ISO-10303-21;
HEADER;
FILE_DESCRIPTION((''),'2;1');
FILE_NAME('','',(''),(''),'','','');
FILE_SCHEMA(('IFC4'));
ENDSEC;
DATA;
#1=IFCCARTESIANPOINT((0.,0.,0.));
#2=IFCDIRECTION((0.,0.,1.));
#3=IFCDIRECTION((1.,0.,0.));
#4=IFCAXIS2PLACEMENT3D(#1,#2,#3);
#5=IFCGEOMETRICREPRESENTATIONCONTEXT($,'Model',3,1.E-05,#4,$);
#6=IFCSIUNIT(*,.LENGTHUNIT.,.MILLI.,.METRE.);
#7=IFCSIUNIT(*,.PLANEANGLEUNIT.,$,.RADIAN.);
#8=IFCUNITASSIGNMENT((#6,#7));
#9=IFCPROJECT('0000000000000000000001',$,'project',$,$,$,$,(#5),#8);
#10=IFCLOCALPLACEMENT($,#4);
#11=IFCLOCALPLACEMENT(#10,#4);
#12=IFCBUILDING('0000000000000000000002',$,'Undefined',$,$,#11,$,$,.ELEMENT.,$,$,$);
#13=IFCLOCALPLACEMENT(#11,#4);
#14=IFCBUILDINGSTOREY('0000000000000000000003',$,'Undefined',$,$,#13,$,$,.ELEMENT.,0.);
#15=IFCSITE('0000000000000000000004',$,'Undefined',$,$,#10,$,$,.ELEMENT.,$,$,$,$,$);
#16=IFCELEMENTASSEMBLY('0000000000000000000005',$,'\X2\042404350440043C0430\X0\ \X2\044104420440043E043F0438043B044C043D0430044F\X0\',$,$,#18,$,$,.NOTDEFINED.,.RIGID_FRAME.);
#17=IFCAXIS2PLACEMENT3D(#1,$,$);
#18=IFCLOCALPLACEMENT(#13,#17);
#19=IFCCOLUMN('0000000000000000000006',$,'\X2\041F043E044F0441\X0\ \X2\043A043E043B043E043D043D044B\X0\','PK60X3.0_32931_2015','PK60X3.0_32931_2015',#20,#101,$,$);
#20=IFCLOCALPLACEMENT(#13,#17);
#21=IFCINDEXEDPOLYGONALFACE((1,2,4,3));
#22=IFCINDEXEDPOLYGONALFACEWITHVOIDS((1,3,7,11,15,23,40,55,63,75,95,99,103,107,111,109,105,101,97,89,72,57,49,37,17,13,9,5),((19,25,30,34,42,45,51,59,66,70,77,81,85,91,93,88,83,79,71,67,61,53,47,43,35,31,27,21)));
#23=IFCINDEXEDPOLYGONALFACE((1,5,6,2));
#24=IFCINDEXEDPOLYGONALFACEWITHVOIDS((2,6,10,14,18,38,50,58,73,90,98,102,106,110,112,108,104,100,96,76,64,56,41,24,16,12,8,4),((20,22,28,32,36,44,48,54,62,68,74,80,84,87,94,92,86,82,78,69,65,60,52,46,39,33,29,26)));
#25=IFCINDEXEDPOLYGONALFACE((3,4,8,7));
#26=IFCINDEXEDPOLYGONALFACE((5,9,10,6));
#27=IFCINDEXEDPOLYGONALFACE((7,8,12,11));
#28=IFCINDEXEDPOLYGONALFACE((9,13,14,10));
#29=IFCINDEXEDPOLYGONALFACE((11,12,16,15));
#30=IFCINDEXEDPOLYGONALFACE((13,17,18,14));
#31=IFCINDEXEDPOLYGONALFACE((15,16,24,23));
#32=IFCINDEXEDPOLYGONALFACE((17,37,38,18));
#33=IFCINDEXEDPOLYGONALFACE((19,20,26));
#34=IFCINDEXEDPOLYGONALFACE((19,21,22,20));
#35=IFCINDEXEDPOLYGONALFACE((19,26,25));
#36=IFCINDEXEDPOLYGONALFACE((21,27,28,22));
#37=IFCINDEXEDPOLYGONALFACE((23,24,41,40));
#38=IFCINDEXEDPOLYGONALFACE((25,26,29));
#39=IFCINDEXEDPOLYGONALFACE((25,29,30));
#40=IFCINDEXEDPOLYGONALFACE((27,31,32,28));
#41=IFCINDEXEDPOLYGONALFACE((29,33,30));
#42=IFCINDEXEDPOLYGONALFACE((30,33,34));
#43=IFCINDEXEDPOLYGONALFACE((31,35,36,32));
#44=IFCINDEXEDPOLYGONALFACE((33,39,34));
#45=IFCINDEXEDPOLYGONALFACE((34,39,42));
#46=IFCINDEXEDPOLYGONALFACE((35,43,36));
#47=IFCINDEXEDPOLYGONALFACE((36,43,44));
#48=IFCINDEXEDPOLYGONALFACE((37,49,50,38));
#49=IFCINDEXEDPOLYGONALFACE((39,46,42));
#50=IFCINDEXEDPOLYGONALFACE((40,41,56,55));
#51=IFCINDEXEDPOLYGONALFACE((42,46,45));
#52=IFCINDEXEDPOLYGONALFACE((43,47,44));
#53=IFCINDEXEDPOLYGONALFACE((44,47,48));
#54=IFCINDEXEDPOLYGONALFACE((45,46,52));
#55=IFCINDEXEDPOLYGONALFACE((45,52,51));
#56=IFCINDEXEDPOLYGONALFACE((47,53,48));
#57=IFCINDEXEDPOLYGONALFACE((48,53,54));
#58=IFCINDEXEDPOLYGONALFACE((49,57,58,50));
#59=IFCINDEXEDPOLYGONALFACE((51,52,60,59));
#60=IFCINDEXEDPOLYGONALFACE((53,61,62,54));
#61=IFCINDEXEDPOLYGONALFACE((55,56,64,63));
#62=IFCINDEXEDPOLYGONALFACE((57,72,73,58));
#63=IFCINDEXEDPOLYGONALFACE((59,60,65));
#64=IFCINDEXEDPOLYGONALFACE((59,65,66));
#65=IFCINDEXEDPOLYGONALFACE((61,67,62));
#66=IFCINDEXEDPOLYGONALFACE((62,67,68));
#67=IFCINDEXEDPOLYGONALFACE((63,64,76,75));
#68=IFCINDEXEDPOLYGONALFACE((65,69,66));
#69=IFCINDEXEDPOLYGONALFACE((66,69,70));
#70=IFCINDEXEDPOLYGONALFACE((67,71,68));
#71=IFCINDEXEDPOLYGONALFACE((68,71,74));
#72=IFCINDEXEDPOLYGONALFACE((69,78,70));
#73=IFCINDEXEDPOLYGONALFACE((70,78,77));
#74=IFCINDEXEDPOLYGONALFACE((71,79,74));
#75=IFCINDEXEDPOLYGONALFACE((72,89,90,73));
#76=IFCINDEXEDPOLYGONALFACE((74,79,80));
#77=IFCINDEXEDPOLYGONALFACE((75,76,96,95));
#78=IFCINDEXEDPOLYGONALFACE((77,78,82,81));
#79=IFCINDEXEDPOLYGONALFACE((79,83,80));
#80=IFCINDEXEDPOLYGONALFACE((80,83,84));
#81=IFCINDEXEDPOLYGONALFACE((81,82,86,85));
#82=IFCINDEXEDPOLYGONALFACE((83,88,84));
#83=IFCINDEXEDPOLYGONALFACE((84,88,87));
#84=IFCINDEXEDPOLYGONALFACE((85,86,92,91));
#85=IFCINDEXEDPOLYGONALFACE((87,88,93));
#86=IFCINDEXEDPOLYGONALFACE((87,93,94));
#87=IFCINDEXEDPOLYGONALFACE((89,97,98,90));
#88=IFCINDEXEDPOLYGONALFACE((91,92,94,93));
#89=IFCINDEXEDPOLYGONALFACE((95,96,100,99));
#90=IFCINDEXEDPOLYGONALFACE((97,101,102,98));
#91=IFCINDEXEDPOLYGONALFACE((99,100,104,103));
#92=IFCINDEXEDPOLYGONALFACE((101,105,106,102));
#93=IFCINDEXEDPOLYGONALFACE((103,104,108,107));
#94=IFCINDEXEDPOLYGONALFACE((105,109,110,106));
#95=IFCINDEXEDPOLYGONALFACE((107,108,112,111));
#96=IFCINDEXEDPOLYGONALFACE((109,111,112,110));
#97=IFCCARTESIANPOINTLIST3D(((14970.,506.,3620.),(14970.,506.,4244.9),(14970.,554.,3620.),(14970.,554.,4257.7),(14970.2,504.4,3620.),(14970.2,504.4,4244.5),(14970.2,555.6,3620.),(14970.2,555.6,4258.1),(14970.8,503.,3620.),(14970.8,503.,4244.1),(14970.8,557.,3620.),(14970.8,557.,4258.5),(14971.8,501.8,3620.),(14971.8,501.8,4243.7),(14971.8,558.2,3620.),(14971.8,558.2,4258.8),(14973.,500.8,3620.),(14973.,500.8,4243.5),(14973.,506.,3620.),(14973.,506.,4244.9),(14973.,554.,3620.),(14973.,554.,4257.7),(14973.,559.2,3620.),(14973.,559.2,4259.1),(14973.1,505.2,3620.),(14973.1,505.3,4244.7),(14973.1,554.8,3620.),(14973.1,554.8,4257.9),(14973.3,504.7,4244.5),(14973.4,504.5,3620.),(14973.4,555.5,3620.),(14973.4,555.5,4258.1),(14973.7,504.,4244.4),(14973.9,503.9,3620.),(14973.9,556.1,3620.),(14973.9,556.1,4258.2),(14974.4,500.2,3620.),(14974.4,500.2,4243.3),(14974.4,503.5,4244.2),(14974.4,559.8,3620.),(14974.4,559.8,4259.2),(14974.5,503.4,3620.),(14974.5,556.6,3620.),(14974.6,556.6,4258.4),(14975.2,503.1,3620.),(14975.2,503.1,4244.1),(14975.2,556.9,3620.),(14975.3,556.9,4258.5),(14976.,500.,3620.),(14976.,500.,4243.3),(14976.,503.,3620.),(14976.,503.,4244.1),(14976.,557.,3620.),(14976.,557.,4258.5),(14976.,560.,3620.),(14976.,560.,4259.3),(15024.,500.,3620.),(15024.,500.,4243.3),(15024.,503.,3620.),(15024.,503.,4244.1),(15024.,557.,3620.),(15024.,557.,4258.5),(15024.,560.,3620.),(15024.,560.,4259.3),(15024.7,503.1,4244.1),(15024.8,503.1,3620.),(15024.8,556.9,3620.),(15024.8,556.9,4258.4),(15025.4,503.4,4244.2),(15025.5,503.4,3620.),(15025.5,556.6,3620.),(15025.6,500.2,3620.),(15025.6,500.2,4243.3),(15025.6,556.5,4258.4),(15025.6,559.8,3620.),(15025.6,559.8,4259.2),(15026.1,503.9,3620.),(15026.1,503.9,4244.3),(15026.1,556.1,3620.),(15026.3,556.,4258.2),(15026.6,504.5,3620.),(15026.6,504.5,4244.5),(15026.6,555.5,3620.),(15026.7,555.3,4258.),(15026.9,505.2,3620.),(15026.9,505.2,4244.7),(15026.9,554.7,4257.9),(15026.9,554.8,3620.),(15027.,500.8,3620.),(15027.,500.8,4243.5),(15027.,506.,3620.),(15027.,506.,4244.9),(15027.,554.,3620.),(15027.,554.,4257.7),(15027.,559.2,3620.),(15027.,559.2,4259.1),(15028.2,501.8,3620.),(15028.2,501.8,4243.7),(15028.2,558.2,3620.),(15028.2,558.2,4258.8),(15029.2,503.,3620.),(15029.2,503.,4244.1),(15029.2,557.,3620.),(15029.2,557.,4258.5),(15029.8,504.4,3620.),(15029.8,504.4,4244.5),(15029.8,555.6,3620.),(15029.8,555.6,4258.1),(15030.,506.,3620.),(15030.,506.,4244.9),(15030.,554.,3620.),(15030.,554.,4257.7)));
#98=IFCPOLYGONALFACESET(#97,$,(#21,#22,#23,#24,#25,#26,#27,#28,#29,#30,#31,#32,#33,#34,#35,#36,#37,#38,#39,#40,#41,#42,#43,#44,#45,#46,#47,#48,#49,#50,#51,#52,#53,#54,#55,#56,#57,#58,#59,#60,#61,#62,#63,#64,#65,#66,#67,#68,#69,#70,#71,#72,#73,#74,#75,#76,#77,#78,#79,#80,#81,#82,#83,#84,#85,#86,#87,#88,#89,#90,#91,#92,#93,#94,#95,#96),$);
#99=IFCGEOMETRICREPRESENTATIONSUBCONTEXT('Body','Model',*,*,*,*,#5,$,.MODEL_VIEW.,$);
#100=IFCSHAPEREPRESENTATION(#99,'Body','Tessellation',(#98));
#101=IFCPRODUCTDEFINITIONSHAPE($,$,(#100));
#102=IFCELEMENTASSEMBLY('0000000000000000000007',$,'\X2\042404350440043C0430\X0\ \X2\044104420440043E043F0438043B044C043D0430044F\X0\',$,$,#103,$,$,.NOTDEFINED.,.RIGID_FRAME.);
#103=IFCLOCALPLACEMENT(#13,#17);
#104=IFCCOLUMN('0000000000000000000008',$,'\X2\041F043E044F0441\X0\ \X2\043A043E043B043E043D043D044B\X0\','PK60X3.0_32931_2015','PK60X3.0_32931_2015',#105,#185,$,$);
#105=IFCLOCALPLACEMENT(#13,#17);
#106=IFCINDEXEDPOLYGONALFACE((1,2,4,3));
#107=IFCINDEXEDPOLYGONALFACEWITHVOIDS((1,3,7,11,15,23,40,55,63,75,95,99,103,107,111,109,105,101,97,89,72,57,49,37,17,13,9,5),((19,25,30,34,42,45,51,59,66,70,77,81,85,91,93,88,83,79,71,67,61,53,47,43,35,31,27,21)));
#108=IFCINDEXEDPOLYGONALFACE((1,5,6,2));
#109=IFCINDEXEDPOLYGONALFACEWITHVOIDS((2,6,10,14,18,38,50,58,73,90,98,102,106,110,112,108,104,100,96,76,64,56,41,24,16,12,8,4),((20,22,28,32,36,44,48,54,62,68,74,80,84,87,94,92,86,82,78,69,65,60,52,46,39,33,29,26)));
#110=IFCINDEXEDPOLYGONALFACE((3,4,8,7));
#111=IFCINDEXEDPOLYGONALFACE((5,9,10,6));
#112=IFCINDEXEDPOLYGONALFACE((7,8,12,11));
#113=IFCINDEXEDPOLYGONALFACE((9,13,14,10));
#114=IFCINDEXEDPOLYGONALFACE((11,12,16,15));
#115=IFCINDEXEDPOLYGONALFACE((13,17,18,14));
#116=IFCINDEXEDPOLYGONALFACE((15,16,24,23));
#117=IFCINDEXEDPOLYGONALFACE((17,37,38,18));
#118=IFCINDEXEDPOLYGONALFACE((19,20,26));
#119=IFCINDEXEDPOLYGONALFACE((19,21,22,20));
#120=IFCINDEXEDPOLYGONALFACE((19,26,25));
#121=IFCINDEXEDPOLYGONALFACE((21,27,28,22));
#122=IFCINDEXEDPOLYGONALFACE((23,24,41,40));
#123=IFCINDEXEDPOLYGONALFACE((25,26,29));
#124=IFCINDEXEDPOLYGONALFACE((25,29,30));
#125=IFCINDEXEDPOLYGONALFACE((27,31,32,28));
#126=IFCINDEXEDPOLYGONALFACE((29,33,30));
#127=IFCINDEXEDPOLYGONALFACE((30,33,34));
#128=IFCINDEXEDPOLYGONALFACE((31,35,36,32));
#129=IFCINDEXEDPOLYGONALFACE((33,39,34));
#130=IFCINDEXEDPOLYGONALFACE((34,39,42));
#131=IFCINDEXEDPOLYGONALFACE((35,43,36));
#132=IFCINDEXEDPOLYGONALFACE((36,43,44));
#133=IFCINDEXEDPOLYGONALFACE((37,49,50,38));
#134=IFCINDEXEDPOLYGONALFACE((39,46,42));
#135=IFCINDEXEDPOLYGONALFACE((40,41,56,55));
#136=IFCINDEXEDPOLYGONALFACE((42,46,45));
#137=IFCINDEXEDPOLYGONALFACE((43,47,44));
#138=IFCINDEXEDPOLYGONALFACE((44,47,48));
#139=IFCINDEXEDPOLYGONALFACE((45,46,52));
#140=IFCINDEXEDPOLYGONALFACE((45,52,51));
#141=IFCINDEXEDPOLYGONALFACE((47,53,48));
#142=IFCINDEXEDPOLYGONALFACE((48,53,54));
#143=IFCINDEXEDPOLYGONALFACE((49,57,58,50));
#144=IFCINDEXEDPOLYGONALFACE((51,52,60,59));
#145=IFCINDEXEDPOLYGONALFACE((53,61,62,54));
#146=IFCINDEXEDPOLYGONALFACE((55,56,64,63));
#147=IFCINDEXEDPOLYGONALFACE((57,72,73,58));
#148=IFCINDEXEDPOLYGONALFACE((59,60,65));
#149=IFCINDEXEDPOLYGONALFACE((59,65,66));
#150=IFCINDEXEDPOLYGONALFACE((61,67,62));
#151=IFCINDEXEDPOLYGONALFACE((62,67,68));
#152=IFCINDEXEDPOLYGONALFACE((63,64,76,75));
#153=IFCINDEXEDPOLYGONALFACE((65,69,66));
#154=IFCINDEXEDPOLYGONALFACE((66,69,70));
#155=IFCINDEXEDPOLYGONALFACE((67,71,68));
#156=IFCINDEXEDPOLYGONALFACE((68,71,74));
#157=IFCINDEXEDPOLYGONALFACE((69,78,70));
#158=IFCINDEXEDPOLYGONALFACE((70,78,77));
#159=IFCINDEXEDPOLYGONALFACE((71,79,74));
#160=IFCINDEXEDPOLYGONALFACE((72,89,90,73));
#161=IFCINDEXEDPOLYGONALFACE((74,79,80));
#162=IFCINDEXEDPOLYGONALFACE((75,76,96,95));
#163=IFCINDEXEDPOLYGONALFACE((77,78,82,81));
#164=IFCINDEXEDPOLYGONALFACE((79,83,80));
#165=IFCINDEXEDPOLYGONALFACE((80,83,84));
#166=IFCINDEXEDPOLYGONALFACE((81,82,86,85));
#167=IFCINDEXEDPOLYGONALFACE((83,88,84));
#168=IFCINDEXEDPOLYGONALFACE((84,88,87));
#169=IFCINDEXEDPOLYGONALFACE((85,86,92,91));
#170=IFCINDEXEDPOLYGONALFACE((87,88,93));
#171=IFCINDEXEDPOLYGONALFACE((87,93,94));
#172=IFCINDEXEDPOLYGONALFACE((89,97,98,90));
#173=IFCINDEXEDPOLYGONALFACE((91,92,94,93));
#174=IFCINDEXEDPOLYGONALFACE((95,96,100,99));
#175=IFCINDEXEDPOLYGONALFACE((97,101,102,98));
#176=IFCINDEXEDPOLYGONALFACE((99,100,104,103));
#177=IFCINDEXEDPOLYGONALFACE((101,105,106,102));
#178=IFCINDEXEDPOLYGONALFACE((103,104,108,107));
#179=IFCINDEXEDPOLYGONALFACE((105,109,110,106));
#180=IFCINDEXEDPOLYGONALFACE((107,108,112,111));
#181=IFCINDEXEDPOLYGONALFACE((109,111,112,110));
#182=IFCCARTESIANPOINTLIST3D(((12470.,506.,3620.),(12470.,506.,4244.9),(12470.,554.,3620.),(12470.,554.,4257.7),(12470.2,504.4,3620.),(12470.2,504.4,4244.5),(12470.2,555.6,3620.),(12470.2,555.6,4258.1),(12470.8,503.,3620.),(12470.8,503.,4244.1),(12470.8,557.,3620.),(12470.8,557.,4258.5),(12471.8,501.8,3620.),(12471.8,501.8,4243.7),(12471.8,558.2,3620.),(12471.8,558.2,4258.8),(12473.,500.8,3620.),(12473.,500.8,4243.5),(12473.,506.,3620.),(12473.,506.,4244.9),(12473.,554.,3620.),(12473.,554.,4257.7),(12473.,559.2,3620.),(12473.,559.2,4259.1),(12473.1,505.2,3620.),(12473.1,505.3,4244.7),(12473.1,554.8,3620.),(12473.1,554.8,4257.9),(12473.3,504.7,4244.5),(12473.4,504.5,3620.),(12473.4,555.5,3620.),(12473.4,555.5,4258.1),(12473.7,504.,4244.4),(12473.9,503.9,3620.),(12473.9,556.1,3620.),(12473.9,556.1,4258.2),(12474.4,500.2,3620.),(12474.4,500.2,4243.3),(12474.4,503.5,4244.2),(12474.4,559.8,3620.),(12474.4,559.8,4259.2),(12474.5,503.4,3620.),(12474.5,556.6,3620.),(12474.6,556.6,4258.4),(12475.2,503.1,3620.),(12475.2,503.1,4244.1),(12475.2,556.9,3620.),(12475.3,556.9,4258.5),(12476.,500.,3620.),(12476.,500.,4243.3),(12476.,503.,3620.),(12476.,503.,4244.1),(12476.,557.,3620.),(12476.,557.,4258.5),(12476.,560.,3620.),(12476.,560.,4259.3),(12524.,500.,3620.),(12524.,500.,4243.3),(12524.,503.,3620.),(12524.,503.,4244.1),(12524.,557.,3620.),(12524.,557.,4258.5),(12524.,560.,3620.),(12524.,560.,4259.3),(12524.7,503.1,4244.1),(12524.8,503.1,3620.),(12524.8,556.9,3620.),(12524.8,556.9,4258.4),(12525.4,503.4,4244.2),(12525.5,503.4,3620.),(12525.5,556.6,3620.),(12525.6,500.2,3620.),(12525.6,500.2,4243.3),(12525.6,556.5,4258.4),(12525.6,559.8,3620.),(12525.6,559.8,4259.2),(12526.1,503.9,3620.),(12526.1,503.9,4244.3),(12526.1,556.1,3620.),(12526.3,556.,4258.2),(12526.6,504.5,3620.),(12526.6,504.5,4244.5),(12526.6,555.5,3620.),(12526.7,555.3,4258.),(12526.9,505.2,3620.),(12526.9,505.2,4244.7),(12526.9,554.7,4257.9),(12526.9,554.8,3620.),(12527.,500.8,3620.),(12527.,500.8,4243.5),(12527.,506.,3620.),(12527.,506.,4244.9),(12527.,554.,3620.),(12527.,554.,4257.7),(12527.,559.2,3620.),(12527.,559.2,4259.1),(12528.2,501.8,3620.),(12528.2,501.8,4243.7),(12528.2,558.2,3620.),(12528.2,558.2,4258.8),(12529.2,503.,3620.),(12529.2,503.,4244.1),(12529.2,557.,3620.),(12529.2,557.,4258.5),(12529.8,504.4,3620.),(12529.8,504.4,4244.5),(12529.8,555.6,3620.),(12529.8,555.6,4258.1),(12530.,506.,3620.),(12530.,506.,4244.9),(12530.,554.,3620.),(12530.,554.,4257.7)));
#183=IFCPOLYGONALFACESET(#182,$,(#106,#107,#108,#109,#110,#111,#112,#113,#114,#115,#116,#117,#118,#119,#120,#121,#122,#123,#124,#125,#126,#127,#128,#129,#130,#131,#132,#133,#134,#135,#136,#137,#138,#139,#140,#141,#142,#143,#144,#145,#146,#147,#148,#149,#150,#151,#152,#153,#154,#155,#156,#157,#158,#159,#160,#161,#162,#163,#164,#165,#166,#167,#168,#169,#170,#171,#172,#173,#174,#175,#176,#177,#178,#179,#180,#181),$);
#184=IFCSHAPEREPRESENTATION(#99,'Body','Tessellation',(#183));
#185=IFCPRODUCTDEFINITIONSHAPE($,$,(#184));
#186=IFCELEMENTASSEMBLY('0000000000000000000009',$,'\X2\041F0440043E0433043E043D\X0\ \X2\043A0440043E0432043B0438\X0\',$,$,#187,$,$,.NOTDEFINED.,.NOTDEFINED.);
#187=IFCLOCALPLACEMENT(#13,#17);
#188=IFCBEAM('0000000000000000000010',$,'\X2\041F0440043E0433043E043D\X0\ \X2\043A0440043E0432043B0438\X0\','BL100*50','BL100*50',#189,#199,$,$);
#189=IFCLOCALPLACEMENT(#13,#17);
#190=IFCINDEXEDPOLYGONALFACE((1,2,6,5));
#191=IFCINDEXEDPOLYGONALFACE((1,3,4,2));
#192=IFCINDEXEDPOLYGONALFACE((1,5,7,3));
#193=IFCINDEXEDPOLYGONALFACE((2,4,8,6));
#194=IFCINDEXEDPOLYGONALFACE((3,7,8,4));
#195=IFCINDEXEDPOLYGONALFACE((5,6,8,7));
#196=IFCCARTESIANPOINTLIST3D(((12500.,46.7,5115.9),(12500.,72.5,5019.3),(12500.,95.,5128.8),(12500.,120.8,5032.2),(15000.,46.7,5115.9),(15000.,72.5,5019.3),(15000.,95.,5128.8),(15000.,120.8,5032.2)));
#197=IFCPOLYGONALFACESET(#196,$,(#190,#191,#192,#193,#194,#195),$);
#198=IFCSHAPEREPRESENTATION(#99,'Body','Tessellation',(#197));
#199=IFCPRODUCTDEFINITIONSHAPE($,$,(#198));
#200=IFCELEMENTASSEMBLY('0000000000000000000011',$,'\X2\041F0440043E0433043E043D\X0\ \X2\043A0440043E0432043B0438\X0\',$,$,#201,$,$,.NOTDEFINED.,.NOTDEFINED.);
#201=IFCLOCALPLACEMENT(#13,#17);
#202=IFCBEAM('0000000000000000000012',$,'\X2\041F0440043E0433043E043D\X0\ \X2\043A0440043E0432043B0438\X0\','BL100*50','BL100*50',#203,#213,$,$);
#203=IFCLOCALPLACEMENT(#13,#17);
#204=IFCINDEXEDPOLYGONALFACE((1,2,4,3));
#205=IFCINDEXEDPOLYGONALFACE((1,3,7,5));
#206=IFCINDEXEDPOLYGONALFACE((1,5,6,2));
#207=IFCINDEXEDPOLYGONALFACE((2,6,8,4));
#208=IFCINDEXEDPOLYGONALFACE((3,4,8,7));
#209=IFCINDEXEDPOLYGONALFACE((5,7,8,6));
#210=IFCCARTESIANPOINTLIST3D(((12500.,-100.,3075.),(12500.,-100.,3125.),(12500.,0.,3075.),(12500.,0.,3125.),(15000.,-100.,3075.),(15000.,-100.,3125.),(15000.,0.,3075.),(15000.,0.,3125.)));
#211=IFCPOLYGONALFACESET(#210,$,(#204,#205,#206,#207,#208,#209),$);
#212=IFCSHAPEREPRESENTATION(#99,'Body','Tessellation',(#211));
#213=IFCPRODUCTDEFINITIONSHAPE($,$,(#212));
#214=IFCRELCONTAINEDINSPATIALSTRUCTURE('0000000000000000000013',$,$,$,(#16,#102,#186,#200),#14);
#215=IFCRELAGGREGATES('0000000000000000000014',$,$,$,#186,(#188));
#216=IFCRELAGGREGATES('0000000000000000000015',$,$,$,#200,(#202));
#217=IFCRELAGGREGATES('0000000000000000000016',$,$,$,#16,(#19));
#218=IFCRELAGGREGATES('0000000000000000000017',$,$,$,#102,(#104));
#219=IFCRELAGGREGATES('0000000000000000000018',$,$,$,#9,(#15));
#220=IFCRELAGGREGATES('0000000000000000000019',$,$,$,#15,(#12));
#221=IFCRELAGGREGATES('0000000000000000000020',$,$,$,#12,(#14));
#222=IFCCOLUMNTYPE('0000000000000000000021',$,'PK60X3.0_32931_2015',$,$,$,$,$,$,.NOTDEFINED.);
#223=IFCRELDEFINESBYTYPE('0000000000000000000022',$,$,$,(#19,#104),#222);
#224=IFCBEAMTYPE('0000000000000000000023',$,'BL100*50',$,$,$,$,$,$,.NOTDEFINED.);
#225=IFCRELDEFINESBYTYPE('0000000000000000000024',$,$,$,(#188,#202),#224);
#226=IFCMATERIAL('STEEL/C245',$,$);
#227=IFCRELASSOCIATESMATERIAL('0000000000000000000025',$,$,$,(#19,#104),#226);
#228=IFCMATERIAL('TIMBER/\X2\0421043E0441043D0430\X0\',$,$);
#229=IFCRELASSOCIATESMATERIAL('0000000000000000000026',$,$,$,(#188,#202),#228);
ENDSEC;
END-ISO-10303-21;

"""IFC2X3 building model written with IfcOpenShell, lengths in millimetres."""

from ifc_helpers import new_model, si_unit, frame, origin_with_axes, origin_2d_with_axis, place, context, subcontext, project, spatial, rectangle, hollow_rectangle, extrude, clip, halfspace, material, type_object, element, aggregate, save


model = new_model("IFC2X3")

# Units and contexts
model_context = context("Model", 3, precision=1e-05, world=origin_with_axes())
body_context = subcontext(model_context, "Body", "Model", "MODEL_VIEW")
ifc_project = project(units=[si_unit("LENGTHUNIT", "METRE", prefix="MILLI"), si_unit("PLANEANGLEUNIT", "RADIAN")], contexts=[model_context])

# Site, building, storey
site_placement = place(None, origin_with_axes())
site = spatial("IfcSite", under=ifc_project, at=site_placement, Name="Undefined", CompositionType="ELEMENT")
building_placement = place(site_placement, origin_with_axes())
building = spatial("IfcBuilding", under=site, at=building_placement, Name="Undefined", CompositionType="ELEMENT")
storey_placement = place(building_placement, origin_with_axes())
storey = spatial("IfcBuildingStorey", under=building, at=storey_placement, Name="Undefined", CompositionType="ELEMENT", Elevation=0.0)

# Element assemblies, columns
assembly_1_placement = place(storey_placement, origin_with_axes())
assembly_1 = element("IfcElementAssembly", 1, at=assembly_1_placement, inside=storey, Name="Ферма стропильная", AssemblyPlace="NOTDEFINED", PredefinedType="RIGID_FRAME")
ifc_material_1 = material(Name="STEEL/C245")
column_type = type_object("IfcColumnType", Name="PK60X3.0_32931_2015", PredefinedType="NOTDEFINED")
column_1_placement = place(assembly_1_placement, frame((15000.0, 530.0, 3620.0), z_axis=(0.0, 0.0, 1.0), x_axis=(-1.0, 0.0, 0.0)))
column_1 = element("IfcColumn", 2, at=column_1_placement, type_object=column_type, material=ifc_material_1, Name="Пояс колонны", Description="PK60X3.0_32931_2015", ObjectType="PK60X3.0_32931_2015", context=body_context, shape_type="Clipping", body=[
    clip(extrude(hollow_rectangle(XDim=60.0, YDim=60.0, WallThickness=3.0, InnerFilletRadius=3.0, OuterFilletRadius=6.0, at=origin_2d_with_axis()), frame((0.0, 0.0, 639.4), z_axis=(0.0, 0.0, -1.0), x_axis=(0.0, 1.0, 0.0)), (0.0, 0.0, 1.0), 639.4), halfspace(frame((0.0, 57.3, 616.0), z_axis=(0.0, -0.257663, -0.966235), x_axis=(-1.0, 0.0, 0.0)), True)),
])
assembly_2_placement = place(storey_placement, origin_with_axes())
assembly_2 = element("IfcElementAssembly", 3, at=assembly_2_placement, inside=storey, Name="Ферма стропильная", AssemblyPlace="NOTDEFINED", PredefinedType="RIGID_FRAME")
column_2_placement = place(assembly_2_placement, frame((12500.0, 530.0, 3620.0), z_axis=(0.0, 0.0, 1.0), x_axis=(-1.0, 0.0, 0.0)))
column_2 = element("IfcColumn", 4, at=column_2_placement, type_object=column_type, material=ifc_material_1, Name="Пояс колонны", Description="PK60X3.0_32931_2015", ObjectType="PK60X3.0_32931_2015", context=body_context, shape_type="Clipping", body=[
    clip(extrude(hollow_rectangle(XDim=60.0, YDim=60.0, WallThickness=3.0, InnerFilletRadius=3.0, OuterFilletRadius=6.0, at=origin_2d_with_axis()), frame((0.0, 0.0, 639.4), z_axis=(0.0, 0.0, -1.0), x_axis=(0.0, 1.0, 0.0)), (0.0, 0.0, 1.0), 639.4), halfspace(frame((0.0, 57.3, 616.0), z_axis=(0.0, -0.257663, -0.966235), x_axis=(-1.0, 0.0, 0.0)), True)),
])

# Element assemblies, beams
assembly_3_placement = place(storey_placement, origin_with_axes())
assembly_3 = element("IfcElementAssembly", 5, at=assembly_3_placement, inside=storey, Name="Прогон кровли", AssemblyPlace="NOTDEFINED", PredefinedType="NOTDEFINED")
ifc_material_2 = material(Name="TIMBER/Сосна")
beam_type_1 = type_object("IfcBeamType", Name="BL100*50", PredefinedType="NOTDEFINED")
beam_1_placement = place(assembly_3_placement, frame((12500.0, 83.7, 5074.1), z_axis=(0.0, 0.257663, -0.966235), x_axis=(1.0, 0.0, 0.0)))
beam_1 = element("IfcBeam", 6, at=beam_1_placement, type_object=beam_type_1, material=ifc_material_2, Name="Прогон кровли", Description="BL100*50", ObjectType="BL100*50", context=body_context, shape_type="SweptSolid", body=[
    extrude(rectangle(XDim=50.0, YDim=100.0, at=origin_2d_with_axis()), frame((2500.0, 0.0, 0.0), z_axis=(-1.0, 0.0, 0.0), x_axis=(0.0, -1.0, 0.0)), (0.0, 0.0, 1.0), 2500.0),
])
aggregate(assembly_3, [beam_1])
assembly_4_placement = place(storey_placement, origin_with_axes())
assembly_4 = element("IfcElementAssembly", 7, at=assembly_4_placement, inside=storey, Name="Прогон кровли", AssemblyPlace="NOTDEFINED", PredefinedType="NOTDEFINED")
beam_2_placement = place(assembly_4_placement, frame((12500.0, -50.0, 3100.0), z_axis=(0.0, -1.0, 0.0), x_axis=(1.0, 0.0, 0.0)))
beam_2 = element("IfcBeam", 8, at=beam_2_placement, type_object=beam_type_1, material=ifc_material_2, Name="Прогон кровли", Description="BL100*50", ObjectType="BL100*50", context=body_context, shape_type="SweptSolid", body=[
    extrude(rectangle(XDim=50.0, YDim=100.0, at=origin_2d_with_axis()), frame((2500.0, 0.0, 0.0), z_axis=(-1.0, 0.0, 0.0), x_axis=(0.0, -1.0, 0.0)), (0.0, 0.0, 1.0), 2500.0),
])
aggregate(assembly_4, [beam_2])

aggregate(assembly_1, [column_1])
aggregate(assembly_2, [column_2])

save(model, "model.ifc")
